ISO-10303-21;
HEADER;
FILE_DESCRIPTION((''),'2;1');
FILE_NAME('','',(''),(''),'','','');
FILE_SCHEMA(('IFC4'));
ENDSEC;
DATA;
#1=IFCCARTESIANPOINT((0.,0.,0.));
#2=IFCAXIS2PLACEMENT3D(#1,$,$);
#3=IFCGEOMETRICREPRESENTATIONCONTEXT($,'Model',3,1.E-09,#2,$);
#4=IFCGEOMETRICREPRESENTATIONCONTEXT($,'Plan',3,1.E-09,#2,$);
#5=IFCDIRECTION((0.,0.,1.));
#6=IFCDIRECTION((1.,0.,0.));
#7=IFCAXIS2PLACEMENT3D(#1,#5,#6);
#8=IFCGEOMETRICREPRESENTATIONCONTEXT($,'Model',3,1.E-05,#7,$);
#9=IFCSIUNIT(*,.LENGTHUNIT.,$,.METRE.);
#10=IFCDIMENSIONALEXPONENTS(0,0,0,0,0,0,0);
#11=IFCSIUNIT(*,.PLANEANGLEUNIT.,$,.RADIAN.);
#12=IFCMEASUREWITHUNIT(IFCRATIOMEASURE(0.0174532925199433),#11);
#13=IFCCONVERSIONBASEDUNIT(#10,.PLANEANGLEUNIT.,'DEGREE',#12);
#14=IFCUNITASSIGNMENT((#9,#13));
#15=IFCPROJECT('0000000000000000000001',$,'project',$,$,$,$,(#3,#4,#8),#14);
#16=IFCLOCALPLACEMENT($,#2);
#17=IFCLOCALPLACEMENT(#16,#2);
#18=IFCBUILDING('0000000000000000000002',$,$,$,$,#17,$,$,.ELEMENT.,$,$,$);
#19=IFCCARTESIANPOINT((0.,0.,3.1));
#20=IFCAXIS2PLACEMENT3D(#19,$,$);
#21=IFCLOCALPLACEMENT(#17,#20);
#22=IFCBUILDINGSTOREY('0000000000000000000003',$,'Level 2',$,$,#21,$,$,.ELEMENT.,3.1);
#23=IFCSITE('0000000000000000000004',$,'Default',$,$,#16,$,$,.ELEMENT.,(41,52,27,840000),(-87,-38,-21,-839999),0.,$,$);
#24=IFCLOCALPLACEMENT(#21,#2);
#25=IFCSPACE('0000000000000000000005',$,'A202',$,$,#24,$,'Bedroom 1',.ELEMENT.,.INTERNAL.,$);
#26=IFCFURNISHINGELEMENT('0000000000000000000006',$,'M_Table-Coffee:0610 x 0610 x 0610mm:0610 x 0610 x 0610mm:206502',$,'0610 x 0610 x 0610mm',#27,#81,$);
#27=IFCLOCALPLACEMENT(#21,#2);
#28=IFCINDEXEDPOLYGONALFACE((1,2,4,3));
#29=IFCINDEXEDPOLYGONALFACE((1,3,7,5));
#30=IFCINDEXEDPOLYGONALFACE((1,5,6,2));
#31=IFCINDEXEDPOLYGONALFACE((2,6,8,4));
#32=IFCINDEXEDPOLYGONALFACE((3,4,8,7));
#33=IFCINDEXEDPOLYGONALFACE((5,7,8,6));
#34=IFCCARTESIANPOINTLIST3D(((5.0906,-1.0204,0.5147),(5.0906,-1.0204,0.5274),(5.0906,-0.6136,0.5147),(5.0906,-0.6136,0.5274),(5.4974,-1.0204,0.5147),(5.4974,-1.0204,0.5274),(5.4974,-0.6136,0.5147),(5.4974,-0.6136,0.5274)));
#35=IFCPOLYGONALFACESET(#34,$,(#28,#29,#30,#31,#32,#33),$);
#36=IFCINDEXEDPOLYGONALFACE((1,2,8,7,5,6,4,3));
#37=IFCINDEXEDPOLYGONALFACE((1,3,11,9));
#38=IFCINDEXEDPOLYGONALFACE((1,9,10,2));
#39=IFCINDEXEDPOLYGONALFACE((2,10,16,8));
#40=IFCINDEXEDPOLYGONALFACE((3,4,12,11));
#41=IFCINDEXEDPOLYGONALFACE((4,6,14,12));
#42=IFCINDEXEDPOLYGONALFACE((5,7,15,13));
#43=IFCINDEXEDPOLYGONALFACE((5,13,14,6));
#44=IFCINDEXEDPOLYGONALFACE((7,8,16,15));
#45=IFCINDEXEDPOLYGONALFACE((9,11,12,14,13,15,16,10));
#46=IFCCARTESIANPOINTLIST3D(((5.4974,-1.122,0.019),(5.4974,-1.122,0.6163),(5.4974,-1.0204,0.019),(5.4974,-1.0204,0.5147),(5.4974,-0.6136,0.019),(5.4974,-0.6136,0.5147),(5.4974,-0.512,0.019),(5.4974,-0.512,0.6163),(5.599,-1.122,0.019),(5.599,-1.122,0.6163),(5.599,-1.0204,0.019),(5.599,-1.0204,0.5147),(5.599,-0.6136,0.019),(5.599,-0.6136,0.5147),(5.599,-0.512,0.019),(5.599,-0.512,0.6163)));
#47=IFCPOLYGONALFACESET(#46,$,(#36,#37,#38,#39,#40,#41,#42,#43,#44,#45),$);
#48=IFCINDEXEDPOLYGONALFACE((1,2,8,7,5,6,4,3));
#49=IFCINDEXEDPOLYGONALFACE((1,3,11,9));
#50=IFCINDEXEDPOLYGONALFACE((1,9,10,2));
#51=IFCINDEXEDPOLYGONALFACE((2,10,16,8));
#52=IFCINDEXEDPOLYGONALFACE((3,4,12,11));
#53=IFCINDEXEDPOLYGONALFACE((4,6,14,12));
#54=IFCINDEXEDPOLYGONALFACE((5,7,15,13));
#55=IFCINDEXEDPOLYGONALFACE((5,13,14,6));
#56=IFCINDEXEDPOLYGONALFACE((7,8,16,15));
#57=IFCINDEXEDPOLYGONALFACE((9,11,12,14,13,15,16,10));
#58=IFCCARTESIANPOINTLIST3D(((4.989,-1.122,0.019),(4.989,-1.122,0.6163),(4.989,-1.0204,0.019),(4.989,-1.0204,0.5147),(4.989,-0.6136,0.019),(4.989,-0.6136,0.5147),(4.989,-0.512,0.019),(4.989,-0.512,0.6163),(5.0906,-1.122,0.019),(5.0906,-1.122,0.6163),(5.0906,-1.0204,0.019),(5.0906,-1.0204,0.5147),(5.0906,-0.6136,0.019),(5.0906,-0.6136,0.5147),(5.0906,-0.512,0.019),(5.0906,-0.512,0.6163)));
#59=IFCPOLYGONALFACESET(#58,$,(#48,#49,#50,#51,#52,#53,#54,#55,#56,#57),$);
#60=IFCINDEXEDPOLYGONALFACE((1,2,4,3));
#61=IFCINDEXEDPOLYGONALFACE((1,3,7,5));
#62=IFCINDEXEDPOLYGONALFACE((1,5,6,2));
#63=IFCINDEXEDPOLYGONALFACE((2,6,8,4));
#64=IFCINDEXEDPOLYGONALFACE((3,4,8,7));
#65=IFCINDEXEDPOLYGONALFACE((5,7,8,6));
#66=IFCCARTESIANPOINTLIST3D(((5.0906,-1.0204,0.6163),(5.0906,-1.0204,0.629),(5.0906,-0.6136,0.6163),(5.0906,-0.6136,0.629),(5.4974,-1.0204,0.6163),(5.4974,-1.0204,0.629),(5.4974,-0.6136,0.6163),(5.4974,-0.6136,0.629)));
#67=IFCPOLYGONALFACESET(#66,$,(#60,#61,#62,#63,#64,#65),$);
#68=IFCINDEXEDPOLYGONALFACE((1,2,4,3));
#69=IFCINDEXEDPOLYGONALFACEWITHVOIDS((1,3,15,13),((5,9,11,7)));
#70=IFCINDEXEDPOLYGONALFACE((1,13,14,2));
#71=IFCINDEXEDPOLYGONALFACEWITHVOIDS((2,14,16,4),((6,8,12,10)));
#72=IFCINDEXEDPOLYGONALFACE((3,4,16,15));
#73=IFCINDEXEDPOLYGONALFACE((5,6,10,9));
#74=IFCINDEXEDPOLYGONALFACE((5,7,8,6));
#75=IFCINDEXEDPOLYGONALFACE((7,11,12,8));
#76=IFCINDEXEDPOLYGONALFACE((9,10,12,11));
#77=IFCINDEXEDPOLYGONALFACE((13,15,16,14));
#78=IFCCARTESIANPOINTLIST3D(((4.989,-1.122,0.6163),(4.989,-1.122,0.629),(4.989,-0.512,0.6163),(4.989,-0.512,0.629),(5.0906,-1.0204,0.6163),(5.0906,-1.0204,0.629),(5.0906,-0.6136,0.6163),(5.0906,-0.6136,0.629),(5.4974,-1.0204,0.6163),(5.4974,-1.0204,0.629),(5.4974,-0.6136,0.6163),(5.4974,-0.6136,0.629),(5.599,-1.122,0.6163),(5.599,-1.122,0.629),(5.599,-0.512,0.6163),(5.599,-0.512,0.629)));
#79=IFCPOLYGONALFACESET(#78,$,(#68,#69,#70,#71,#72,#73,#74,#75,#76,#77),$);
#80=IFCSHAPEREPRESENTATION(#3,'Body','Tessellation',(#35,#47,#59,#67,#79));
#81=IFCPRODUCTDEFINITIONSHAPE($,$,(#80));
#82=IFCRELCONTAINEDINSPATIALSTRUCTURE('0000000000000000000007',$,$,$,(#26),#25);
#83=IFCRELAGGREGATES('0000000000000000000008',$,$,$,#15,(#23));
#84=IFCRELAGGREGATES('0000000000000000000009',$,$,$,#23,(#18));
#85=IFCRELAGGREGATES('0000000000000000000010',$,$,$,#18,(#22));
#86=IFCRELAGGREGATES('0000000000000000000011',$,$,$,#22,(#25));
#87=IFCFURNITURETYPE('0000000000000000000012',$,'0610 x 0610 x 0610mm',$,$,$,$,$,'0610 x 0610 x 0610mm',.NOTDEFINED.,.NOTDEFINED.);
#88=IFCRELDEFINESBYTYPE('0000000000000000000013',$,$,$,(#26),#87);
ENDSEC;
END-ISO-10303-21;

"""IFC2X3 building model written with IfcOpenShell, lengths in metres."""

from ifc_helpers import new_model, entity, si_unit, converted_unit, frame, origin, origin_with_axes, origin_2d_with_axis, place, context, project, spatial, polyline, rectangle, outline, extrude, source, transform, mapped, type_object, type_shapes, element, save


model = new_model("IFC2X3")

# Units and contexts
model_context_1 = context("Model", 3, precision=1e-09, world=origin())
plan_context = context("Plan", 3, precision=1e-09, world=origin())
model_context_2 = context("Model", 3, precision=1e-05, world=origin_with_axes())
ifc_project = project(units=[si_unit("LENGTHUNIT", "METRE"), converted_unit("PLANEANGLEUNIT", "DEGREE", entity("IfcRatioMeasure", 0.0174532925199433), si_unit("PLANEANGLEUNIT", "RADIAN"), dimensions=[0, 0, 0, 0, 0, 0, 0])], contexts=[model_context_1, plan_context, model_context_2])

# Site, building, storey
site_placement = place(None, origin())
site = spatial("IfcSite", under=ifc_project, at=site_placement, Name="Default", CompositionType="ELEMENT", RefLatitude=(41, 52, 27, 840000), RefLongitude=(-87, -38, -21, -839999), RefElevation=0.0)
building_placement = place(site_placement, origin())
building = spatial("IfcBuilding", under=site, at=building_placement, CompositionType="ELEMENT")
storey_placement = place(building_placement, frame((0.0, 0.0, 3.1)))
storey = spatial("IfcBuildingStorey", under=building, at=storey_placement, Name="Level 2", CompositionType="ELEMENT", Elevation=3.1)

# Shared definitions
furniture_type = type_object("IfcFurnitureType", Name="0610 x 0610 x 0610mm", ElementType="0610 x 0610 x 0610mm", AssemblyPlace="NOTDEFINED")
shared_shape_1 = source(origin(), model_context_1, "Body", "SweptSolid", [
    extrude(rectangle(XDim=0.4068, YDim=0.4068, at=origin_2d_with_axis()), frame((0.0183, 0.0952, 0.4957), z_axis=(0.0, 0.0, 1.0), x_axis=(-1.0, 0.0, 0.0)), (0.0, 0.0, 1.0), 0.0127),
    extrude(outline(polyline([(-0.2732, -0.305), (0.324, -0.305), (0.324, 0.305), (-0.2732, 0.305), (-0.2732, 0.2034), (0.2225, 0.2034), (0.2225, -0.2034), (-0.2732, -0.2034), (-0.2732, -0.305)])), frame((0.2217, 0.0952, 0.2732), z_axis=(1.0, 0.0, 0.0), x_axis=(0.0, 0.0, 1.0)), (0.0, 0.0, 1.0), 0.1016),
    extrude(outline(polyline([(-0.305, -0.3241), (0.305, -0.3241), (0.305, 0.2733), (0.2034, 0.2733), (0.2034, -0.2224), (-0.2034, -0.2224), (-0.2034, 0.2733), (-0.305, 0.2733), (-0.305, -0.3241)])), frame((-0.2867, 0.0952, 0.2733), z_axis=(1.0, 0.0, 0.0), x_axis=(0.0, -1.0, 0.0)), (0.0, 0.0, 1.0), 0.1016),
    extrude(rectangle(XDim=0.4068, YDim=0.4068, at=origin_2d_with_axis()), frame((0.0183, 0.0952, 0.5973), z_axis=(0.0, 0.0, 1.0), x_axis=(-1.0, 0.0, 0.0)), (0.0, 0.0, 1.0), 0.0127),
    extrude(outline(polyline([(-0.305, -0.305), (0.305, -0.305), (0.305, 0.305), (-0.305, 0.305), (-0.305, -0.305)]), holes=[polyline([(-0.2034, -0.2034), (-0.2034, 0.2034), (0.2034, 0.2034), (0.2034, -0.2034), (-0.2034, -0.2034)])]), frame((0.0183, 0.0952, 0.5973), z_axis=(0.0, 0.0, 1.0), x_axis=(-1.0, 0.0, 0.0)), (0.0, 0.0, 1.0), 0.0127),
])
type_shapes(furniture_type, [shared_shape_1])

# Shared definitions
space_1_placement = place(storey_placement, origin())
space_1 = spatial("IfcSpace", under=storey, at=space_1_placement, Name="A202", LongName="Bedroom 1", CompositionType="ELEMENT", InteriorOrExteriorSpace="INTERNAL")

# Furnishing element
furnishing_1_placement = place(space_1_placement, frame((5.2757, -0.9122, 0.019)))
element("IfcFurnishingElement", 1, at=furnishing_1_placement, inside=space_1, type_object=furniture_type, Name="M_Table-Coffee:0610 x 0610 x 0610mm:0610 x 0610 x 0610mm:206502", ObjectType="0610 x 0610 x 0610mm", context=model_context_1, shape_type="MappedRepresentation", body=[
    mapped(shared_shape_1, transform((0.0, 0.0, 0.0), scale=1.0)),
])

save(model, "model.ifc")
